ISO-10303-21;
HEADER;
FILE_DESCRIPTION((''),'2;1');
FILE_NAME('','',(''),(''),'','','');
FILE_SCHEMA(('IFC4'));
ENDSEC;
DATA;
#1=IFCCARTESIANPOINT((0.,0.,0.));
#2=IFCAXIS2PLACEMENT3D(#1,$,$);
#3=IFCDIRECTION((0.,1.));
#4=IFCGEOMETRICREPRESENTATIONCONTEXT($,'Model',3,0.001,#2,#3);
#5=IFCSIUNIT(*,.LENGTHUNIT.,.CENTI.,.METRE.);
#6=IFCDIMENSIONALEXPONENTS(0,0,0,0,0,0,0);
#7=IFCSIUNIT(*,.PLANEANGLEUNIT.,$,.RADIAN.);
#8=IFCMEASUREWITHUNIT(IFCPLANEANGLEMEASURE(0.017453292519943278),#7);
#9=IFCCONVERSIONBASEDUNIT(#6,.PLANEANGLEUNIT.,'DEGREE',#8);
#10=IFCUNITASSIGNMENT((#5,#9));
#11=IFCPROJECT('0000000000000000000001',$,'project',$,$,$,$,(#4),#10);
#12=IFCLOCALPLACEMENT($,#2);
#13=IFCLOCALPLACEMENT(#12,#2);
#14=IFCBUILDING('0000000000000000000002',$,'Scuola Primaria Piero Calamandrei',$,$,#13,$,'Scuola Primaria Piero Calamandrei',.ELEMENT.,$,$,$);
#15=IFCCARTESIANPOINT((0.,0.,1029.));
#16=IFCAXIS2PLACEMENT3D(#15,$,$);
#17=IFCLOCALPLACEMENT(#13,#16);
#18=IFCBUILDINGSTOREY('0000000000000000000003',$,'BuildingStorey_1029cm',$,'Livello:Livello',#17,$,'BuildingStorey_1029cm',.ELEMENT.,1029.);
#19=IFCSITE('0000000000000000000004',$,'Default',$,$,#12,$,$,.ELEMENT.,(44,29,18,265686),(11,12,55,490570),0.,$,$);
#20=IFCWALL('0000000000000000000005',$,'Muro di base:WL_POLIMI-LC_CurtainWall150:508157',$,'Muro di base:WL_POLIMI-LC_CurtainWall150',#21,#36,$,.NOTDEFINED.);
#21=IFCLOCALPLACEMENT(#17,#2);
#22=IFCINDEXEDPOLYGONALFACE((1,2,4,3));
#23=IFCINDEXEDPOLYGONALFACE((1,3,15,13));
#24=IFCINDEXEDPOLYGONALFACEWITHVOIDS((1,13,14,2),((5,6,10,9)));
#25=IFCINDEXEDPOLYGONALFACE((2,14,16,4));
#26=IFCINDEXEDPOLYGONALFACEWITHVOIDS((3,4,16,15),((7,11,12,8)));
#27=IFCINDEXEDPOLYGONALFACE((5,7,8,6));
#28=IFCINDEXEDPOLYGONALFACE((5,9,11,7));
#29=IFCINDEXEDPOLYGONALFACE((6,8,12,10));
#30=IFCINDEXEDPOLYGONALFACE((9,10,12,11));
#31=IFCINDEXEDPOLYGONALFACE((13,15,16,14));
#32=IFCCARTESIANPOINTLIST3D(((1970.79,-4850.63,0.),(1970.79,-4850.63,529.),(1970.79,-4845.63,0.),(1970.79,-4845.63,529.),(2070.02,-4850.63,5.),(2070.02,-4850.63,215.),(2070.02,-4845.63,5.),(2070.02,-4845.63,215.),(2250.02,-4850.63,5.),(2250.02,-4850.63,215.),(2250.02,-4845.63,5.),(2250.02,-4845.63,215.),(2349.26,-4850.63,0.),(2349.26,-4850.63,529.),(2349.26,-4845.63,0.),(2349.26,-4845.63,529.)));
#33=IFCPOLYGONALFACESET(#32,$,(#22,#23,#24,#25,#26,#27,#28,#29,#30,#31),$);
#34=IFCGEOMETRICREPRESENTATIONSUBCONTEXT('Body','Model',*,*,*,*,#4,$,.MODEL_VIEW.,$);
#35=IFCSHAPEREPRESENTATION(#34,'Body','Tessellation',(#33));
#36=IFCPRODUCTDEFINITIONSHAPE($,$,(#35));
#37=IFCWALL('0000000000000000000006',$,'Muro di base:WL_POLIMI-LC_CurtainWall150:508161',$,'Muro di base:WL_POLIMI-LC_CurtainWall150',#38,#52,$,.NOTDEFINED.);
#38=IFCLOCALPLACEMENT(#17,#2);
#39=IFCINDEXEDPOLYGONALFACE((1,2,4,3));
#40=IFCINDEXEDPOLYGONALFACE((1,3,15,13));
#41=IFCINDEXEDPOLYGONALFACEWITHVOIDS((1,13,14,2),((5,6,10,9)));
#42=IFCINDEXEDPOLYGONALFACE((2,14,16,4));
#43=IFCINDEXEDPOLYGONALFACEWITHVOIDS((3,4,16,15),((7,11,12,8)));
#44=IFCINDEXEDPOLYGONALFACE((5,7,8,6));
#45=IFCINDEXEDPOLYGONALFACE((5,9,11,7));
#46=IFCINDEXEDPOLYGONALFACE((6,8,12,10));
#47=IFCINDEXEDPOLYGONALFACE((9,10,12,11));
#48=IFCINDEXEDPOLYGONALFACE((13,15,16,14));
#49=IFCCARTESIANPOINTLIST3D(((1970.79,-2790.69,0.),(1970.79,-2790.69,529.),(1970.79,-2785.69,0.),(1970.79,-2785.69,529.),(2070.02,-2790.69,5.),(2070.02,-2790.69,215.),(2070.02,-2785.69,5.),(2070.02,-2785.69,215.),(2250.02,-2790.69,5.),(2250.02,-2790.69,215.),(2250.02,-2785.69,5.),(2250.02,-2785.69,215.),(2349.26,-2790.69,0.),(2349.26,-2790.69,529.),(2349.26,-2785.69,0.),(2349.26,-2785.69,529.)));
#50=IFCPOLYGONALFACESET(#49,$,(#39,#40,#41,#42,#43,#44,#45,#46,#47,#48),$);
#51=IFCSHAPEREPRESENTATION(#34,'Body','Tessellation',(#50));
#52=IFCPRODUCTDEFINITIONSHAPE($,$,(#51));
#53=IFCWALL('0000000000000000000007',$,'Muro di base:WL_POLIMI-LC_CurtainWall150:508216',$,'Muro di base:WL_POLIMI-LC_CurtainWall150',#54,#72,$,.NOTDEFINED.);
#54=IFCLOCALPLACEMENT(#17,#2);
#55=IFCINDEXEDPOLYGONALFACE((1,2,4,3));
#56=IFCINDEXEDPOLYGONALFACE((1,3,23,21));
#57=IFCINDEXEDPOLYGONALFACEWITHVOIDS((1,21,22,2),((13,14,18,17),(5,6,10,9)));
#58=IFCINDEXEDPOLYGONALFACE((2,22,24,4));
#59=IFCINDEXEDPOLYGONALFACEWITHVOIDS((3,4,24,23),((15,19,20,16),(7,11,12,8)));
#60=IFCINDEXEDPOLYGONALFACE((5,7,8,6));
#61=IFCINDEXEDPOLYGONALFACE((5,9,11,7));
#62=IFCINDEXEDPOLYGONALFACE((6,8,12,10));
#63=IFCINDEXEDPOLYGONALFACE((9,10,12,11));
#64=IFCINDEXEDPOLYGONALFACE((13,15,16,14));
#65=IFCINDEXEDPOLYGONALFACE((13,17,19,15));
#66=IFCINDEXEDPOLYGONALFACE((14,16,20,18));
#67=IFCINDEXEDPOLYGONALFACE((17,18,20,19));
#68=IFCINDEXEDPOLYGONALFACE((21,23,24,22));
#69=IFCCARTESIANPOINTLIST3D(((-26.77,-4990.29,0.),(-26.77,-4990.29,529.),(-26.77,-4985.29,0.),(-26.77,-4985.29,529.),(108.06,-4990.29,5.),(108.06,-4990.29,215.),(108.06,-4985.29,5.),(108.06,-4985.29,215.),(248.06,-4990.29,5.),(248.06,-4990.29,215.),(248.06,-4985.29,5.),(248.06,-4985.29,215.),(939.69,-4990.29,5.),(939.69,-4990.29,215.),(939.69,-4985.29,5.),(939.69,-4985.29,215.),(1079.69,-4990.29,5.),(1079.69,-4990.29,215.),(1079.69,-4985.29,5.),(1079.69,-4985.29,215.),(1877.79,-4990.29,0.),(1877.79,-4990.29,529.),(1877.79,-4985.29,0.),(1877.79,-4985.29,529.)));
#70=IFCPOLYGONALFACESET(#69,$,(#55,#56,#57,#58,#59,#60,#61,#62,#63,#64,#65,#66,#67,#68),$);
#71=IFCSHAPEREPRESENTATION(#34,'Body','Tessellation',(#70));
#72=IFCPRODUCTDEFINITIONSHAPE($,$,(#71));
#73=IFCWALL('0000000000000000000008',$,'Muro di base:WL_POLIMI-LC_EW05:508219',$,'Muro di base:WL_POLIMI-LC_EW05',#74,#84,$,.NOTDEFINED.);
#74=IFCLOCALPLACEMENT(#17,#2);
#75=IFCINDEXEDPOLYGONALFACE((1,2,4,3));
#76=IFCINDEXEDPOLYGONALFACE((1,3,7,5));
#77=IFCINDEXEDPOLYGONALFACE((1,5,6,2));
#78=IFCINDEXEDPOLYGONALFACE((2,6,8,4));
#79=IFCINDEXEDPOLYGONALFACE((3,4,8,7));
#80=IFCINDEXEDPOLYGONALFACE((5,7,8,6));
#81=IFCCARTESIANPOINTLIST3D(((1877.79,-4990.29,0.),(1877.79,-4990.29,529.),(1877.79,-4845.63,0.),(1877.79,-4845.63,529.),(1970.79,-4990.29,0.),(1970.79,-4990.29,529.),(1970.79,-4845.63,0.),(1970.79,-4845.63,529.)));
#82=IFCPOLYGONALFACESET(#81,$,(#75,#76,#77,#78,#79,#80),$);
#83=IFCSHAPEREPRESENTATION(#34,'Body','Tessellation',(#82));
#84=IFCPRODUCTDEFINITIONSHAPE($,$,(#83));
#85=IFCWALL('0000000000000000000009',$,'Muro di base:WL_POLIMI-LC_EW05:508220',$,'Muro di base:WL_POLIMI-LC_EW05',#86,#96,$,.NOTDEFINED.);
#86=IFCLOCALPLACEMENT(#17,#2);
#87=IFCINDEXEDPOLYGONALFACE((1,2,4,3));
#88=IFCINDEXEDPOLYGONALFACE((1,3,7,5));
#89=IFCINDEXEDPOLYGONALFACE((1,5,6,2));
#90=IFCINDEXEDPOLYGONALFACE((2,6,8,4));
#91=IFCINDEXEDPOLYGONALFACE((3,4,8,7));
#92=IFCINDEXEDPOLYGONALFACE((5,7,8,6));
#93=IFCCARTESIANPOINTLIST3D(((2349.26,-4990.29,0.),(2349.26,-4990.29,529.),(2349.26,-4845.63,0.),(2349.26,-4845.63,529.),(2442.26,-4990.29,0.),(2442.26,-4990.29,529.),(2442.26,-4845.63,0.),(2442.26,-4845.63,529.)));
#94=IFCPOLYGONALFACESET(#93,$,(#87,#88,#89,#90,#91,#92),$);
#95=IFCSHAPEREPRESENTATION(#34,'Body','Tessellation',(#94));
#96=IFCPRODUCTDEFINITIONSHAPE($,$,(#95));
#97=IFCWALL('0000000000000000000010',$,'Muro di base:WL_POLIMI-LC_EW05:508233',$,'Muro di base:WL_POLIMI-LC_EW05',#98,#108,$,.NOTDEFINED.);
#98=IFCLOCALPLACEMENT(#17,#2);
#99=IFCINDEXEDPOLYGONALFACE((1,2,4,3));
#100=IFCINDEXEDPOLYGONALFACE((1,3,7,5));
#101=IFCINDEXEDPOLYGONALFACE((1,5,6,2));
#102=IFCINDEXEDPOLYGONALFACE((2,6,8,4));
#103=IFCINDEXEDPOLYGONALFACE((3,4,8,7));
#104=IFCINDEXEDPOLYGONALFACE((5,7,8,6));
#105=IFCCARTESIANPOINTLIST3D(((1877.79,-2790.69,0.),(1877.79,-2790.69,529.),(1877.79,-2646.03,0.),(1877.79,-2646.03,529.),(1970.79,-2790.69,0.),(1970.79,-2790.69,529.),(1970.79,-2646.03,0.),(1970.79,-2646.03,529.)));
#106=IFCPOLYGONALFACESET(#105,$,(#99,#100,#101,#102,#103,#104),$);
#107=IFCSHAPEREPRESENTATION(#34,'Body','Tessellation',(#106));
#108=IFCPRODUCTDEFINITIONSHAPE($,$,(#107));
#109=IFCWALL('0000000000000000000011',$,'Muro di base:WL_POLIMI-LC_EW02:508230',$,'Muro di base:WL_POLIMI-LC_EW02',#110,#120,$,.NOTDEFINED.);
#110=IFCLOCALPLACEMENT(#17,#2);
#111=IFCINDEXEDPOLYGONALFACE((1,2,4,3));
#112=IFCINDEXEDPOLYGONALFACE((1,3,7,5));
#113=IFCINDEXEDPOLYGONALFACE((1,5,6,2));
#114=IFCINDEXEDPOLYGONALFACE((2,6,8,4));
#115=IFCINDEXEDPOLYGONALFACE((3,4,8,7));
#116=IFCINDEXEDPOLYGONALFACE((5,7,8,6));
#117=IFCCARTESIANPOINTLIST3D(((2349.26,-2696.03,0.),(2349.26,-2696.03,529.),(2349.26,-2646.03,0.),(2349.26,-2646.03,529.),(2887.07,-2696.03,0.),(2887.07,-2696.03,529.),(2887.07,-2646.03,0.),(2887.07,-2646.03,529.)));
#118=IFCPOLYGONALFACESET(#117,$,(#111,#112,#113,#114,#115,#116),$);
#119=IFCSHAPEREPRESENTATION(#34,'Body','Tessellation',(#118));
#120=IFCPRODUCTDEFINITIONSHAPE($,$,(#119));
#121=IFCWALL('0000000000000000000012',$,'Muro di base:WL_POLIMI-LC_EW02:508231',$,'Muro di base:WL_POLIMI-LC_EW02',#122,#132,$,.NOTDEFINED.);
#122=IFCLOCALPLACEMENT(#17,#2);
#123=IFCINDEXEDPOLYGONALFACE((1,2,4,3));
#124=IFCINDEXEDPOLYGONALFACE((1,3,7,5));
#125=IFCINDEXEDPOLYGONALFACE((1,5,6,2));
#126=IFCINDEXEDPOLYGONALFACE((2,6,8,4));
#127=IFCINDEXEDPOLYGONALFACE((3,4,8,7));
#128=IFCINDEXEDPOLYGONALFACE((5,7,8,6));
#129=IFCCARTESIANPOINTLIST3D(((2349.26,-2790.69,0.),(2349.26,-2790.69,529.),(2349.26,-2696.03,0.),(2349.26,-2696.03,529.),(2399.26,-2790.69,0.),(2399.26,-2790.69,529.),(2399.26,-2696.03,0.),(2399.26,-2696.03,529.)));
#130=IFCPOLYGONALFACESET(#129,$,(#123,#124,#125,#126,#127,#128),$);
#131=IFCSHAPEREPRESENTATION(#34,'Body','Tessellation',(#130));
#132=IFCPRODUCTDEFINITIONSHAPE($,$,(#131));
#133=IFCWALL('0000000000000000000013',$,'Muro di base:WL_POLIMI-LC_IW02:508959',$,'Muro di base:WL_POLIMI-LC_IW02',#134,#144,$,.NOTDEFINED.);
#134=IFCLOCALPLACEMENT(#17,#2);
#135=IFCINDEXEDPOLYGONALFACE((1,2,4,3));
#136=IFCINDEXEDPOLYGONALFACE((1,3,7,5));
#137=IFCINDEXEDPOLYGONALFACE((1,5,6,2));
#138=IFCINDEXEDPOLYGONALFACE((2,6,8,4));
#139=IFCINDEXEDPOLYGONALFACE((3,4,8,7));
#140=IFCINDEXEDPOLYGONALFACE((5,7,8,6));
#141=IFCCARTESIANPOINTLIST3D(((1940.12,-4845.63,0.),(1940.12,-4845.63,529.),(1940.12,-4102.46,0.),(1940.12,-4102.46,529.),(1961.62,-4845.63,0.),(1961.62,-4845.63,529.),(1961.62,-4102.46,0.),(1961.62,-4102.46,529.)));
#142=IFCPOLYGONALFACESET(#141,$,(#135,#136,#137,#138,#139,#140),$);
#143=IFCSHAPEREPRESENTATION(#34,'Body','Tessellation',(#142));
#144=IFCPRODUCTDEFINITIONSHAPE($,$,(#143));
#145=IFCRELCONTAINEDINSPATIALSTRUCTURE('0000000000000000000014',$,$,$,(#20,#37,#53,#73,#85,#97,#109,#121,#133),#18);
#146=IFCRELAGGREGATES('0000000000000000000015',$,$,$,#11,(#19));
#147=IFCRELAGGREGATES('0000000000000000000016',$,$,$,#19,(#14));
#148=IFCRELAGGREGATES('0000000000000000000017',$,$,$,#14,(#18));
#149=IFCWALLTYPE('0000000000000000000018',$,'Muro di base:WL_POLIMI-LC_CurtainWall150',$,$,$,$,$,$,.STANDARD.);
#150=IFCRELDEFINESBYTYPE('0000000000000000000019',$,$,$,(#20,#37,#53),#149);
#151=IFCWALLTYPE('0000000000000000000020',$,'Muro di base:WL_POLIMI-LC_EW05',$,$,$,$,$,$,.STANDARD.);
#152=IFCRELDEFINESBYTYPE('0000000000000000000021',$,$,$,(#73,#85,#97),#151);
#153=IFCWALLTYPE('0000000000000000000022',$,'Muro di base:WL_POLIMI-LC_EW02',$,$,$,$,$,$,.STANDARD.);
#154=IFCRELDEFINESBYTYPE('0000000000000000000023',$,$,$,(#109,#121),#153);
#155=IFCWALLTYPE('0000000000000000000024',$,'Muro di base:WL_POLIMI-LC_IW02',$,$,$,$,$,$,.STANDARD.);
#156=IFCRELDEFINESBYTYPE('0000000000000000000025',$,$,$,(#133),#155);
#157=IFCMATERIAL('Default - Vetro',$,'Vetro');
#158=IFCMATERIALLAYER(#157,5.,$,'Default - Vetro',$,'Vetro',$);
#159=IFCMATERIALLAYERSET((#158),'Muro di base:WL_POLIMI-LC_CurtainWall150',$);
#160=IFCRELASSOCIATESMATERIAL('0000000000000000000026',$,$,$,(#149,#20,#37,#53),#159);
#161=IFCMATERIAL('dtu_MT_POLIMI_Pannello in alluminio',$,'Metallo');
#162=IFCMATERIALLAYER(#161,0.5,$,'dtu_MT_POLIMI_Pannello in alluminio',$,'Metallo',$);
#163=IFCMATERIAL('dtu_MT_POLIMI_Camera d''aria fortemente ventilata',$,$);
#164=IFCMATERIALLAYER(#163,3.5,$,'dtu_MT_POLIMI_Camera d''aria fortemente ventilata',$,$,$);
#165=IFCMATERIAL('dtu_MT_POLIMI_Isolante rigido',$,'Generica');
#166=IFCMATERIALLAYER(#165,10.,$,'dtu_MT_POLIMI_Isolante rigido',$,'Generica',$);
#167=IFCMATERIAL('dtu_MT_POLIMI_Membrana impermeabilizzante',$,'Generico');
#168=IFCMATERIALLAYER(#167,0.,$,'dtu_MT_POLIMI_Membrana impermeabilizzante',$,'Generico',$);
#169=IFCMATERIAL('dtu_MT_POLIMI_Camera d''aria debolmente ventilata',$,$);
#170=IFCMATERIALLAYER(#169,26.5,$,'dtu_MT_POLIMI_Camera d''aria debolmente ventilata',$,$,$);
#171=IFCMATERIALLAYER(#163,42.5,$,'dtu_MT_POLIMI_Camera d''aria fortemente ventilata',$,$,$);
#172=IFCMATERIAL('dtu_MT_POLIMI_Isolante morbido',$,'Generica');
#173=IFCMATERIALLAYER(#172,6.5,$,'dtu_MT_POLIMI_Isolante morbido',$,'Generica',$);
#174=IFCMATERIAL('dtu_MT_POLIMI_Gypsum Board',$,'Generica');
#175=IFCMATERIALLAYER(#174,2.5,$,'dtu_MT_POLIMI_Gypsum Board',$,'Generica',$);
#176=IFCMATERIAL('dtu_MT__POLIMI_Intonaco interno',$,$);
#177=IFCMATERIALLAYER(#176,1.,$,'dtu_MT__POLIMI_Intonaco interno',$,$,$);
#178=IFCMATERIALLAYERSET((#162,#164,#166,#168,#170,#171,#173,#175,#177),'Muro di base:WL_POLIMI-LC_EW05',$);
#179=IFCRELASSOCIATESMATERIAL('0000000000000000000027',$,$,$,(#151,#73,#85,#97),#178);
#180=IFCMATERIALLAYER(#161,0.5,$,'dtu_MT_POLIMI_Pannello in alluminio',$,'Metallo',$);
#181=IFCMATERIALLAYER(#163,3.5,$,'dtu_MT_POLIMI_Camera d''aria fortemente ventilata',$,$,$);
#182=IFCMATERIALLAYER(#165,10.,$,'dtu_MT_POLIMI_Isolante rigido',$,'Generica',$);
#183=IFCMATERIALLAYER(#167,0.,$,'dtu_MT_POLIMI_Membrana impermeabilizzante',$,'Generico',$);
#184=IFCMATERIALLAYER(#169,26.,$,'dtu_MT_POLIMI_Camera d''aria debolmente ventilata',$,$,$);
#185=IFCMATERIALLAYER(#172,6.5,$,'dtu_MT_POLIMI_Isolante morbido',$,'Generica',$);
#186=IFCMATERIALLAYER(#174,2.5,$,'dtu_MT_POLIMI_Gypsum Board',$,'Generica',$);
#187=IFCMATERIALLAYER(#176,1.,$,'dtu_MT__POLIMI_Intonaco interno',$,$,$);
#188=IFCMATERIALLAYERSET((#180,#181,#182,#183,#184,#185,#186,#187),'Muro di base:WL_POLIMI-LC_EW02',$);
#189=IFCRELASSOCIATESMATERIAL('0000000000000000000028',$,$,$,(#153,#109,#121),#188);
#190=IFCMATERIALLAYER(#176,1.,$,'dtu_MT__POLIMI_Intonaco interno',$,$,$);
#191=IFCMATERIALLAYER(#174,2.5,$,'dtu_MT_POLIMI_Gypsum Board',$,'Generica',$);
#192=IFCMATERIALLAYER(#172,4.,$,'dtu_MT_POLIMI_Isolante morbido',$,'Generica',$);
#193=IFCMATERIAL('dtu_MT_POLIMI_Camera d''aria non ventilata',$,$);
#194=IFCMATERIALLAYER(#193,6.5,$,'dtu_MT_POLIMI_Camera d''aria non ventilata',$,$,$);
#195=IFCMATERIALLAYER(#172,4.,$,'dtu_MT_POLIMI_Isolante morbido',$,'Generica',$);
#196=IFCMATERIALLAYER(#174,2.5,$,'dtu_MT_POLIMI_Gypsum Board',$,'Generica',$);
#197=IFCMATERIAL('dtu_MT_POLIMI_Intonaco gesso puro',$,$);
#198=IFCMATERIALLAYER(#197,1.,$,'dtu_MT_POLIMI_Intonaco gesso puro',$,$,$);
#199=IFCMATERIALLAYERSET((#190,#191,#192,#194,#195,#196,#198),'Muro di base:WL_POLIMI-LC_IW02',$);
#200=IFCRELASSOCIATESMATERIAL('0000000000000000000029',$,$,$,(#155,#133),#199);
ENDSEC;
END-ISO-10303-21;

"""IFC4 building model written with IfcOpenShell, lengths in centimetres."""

from ifc_helpers import new_model, entity, si_unit, converted_unit, direction, frame, frame_2d, origin, place, context, subcontext, project, spatial, rectangle, extrude, material, layer, layer_set, layer_usage, type_object, element, save


model = new_model("IFC4")

# Units and contexts
model_context = context("Model", 3, precision=0.001, world=origin(), true_north=direction((0.0, 1.0)))
body_context = subcontext(model_context, "Body", "Model", "MODEL_VIEW")
ifc_project = project(units=[si_unit("LENGTHUNIT", "METRE", prefix="CENTI"), converted_unit("PLANEANGLEUNIT", "DEGREE", entity("IfcPlaneAngleMeasure", 0.017453292519943278), si_unit("PLANEANGLEUNIT", "RADIAN"), dimensions=[0, 0, 0, 0, 0, 0, 0])], contexts=[model_context])

# Site, building, storey
site_placement = place(None, origin())
site = spatial("IfcSite", under=ifc_project, at=site_placement, Name="Default", CompositionType="ELEMENT", RefLatitude=(44, 29, 18, 265686), RefLongitude=(11, 12, 55, 490570), RefElevation=0.0)
building_placement = place(site_placement, origin())
building = spatial("IfcBuilding", under=site, at=building_placement, Name="Scuola Primaria Piero Calamandrei", LongName="Scuola Primaria Piero Calamandrei", CompositionType="ELEMENT")
storey_placement = place(building_placement, frame((0.0, 0.0, 1029.0)))
storey = spatial("IfcBuildingStorey", under=building, at=storey_placement, Name="BuildingStorey_1029cm", ObjectType="Livello:Livello", LongName="BuildingStorey_1029cm", CompositionType="ELEMENT", Elevation=1029.0)

# Wall, openings
ifc_material_1 = material(Name="Default - Vetro", Category="Vetro")
ifc_layer_1 = layer(ifc_material_1, 5.0, Name="Default - Vetro", Category="Vetro")
ifc_layer_set_1 = layer_set([ifc_layer_1], Name="Muro di base:WL_POLIMI-LC_CurtainWall150")
ifc_layer_usage_1 = layer_usage(ifc_layer_set_1, "AXIS2", "NEGATIVE", 2.5)
wall_type_1 = type_object("IfcWallType", Name="Muro di base:WL_POLIMI-LC_CurtainWall150", PredefinedType="STANDARD", material=ifc_layer_set_1)
wall_1_placement = place(storey_placement, frame((2349.26, -4848.13, 0.0), z_axis=(0.0, 0.0, 1.0), x_axis=(-1.0, 0.0, 0.0)))
wall_1 = element("IfcWall", 1, at=wall_1_placement, inside=storey, type_object=wall_type_1, material=ifc_layer_usage_1, Name="Muro di base:WL_POLIMI-LC_CurtainWall150:508157", ObjectType="Muro di base:WL_POLIMI-LC_CurtainWall150", PredefinedType="NOTDEFINED", context=body_context, shape_type="SweptSolid", body=[
    extrude(rectangle(XDim=5.0, YDim=378.47, at=frame_2d((0.0, 0.0), x_axis=(1.0, 0.0))), frame((189.23, 0.0, 0.0), z_axis=(0.0, 0.0, 1.0), x_axis=(0.0, 1.0, 0.0)), (0.0, 0.0, 1.0), 529.0),
])
opening_1_placement = place(storey_placement, frame((2349.26, -4848.13, 0.0), z_axis=(0.0, 0.0, 1.0), x_axis=(-1.0, 0.0, 0.0)))
element("IfcOpeningElement", 2, at=opening_1_placement, cuts=wall_1, PredefinedType="OPENING", context=body_context, shape_type="SweptSolid", body=[
    extrude(rectangle(XDim=210.0, YDim=180.0, at=frame_2d((0.0, 0.0), x_axis=(0.0, 1.0))), frame((189.23, -2.5, 110.0), z_axis=(0.0, 1.0, 0.0), x_axis=(1.0, 0.0, 0.0)), (0.0, 0.0, 1.0), 5.0),
])
opening_2_placement = place(wall_1_placement, frame((99.23, -2.5, 5.0)))
element("IfcOpeningElement", 3, at=opening_2_placement, cuts=wall_1, PredefinedType="OPENING", context=body_context, shape_type="SweptSolid", body=[
    extrude(rectangle(XDim=210.0, YDim=180.0, at=frame_2d((105.0, 90.0), x_axis=(-1.0, 0.0))), frame((0.0, 0.0, 0.0), z_axis=(0.0, 1.0, 0.0), x_axis=(0.0, 0.0, 1.0)), (0.0, 0.0, 1.0), 5.0),
])

# Wall, opening
ifc_layer_usage_2 = layer_usage(ifc_layer_set_1, "AXIS2", "NEGATIVE", 2.5)
wall_2_placement = place(storey_placement, frame((1970.79, -2788.19, 0.0)))
wall_2 = element("IfcWall", 4, at=wall_2_placement, inside=storey, type_object=wall_type_1, material=ifc_layer_usage_2, Name="Muro di base:WL_POLIMI-LC_CurtainWall150:508161", ObjectType="Muro di base:WL_POLIMI-LC_CurtainWall150", PredefinedType="NOTDEFINED", context=body_context, shape_type="SweptSolid", body=[
    extrude(rectangle(XDim=378.47, YDim=5.0, at=frame_2d((189.23, 0.0), x_axis=(-1.0, 0.0))), origin(), (0.0, 0.0, 1.0), 529.0),
])
opening_3_placement = place(wall_2_placement, frame((99.23, -2.5, 5.0)))
element("IfcOpeningElement", 5, at=opening_3_placement, cuts=wall_2, PredefinedType="OPENING", context=body_context, shape_type="SweptSolid", body=[
    extrude(rectangle(XDim=210.0, YDim=180.0, at=frame_2d((105.0, 90.0), x_axis=(-1.0, 0.0))), frame((0.0, 0.0, 0.0), z_axis=(0.0, 1.0, 0.0), x_axis=(0.0, 0.0, 1.0)), (0.0, 0.0, 1.0), 5.0),
])

# Wall, openings
ifc_layer_usage_3 = layer_usage(ifc_layer_set_1, "AXIS2", "NEGATIVE", 2.5)
wall_3_placement = place(storey_placement, frame((1877.79, -4987.79, 0.0), z_axis=(0.0, 0.0, 1.0), x_axis=(-1.0, 0.0, 0.0)))
wall_3 = element("IfcWall", 6, at=wall_3_placement, inside=storey, type_object=wall_type_1, material=ifc_layer_usage_3, Name="Muro di base:WL_POLIMI-LC_CurtainWall150:508216", ObjectType="Muro di base:WL_POLIMI-LC_CurtainWall150", PredefinedType="NOTDEFINED", context=body_context, shape_type="SweptSolid", body=[
    extrude(rectangle(XDim=1904.56, YDim=5.0, at=frame_2d((952.28, 0.0), x_axis=(-1.0, 0.0))), origin(), (0.0, 0.0, 1.0), 529.0),
])
opening_4_placement = place(wall_3_placement, frame((1629.73, -2.5, 5.0)))
element("IfcOpeningElement", 7, at=opening_4_placement, cuts=wall_3, PredefinedType="OPENING", context=body_context, shape_type="SweptSolid", body=[
    extrude(rectangle(XDim=210.0, YDim=140.0, at=frame_2d((105.0, 70.0), x_axis=(-1.0, 0.0))), frame((0.0, 0.0, 0.0), z_axis=(0.0, 1.0, 0.0), x_axis=(0.0, 0.0, 1.0)), (0.0, 0.0, 1.0), 5.0),
])
opening_5_placement = place(wall_3_placement, frame((798.1, -2.5, 5.0)))
element("IfcOpeningElement", 8, at=opening_5_placement, cuts=wall_3, PredefinedType="OPENING", context=body_context, shape_type="SweptSolid", body=[
    extrude(rectangle(XDim=210.0, YDim=140.0, at=frame_2d((105.0, 70.0), x_axis=(-1.0, 0.0))), frame((0.0, 0.0, 0.0), z_axis=(0.0, 1.0, 0.0), x_axis=(0.0, 0.0, 1.0)), (0.0, 0.0, 1.0), 5.0),
])

# Walls
ifc_material_2 = material(Name="dtu_MT_POLIMI_Pannello in alluminio", Category="Metallo")
ifc_layer_2 = layer(ifc_material_2, 0.5, Name="dtu_MT_POLIMI_Pannello in alluminio", Category="Metallo")
ifc_material_3 = material(Name="dtu_MT_POLIMI_Camera d'aria fortemente ventilata")
ifc_layer_3 = layer(ifc_material_3, 3.5, Name="dtu_MT_POLIMI_Camera d'aria fortemente ventilata")
ifc_material_4 = material(Name="dtu_MT_POLIMI_Isolante rigido", Category="Generica")
ifc_layer_4 = layer(ifc_material_4, 10.0, Name="dtu_MT_POLIMI_Isolante rigido", Category="Generica")
ifc_material_5 = material(Name="dtu_MT_POLIMI_Membrana impermeabilizzante", Category="Generico")
ifc_layer_5 = layer(ifc_material_5, 0.0, Name="dtu_MT_POLIMI_Membrana impermeabilizzante", Category="Generico")
ifc_material_6 = material(Name="dtu_MT_POLIMI_Camera d'aria debolmente ventilata")
ifc_layer_6 = layer(ifc_material_6, 26.5, Name="dtu_MT_POLIMI_Camera d'aria debolmente ventilata")
ifc_layer_7 = layer(ifc_material_3, 42.5, Name="dtu_MT_POLIMI_Camera d'aria fortemente ventilata")
ifc_material_7 = material(Name="dtu_MT_POLIMI_Isolante morbido", Category="Generica")
ifc_layer_8 = layer(ifc_material_7, 6.5, Name="dtu_MT_POLIMI_Isolante morbido", Category="Generica")
ifc_material_8 = material(Name="dtu_MT_POLIMI_Gypsum Board", Category="Generica")
ifc_layer_9 = layer(ifc_material_8, 2.5, Name="dtu_MT_POLIMI_Gypsum Board", Category="Generica")
ifc_material_9 = material(Name="dtu_MT__POLIMI_Intonaco interno")
ifc_layer_10 = layer(ifc_material_9, 1.0, Name="dtu_MT__POLIMI_Intonaco interno")
ifc_layer_set_2 = layer_set([ifc_layer_2, ifc_layer_3, ifc_layer_4, ifc_layer_5, ifc_layer_6, ifc_layer_7, ifc_layer_8, ifc_layer_9, ifc_layer_10], Name="Muro di base:WL_POLIMI-LC_EW05")
ifc_layer_usage_4 = layer_usage(ifc_layer_set_2, "AXIS2", "NEGATIVE", 46.5)
wall_type_2 = type_object("IfcWallType", Name="Muro di base:WL_POLIMI-LC_EW05", PredefinedType="STANDARD", material=ifc_layer_set_2)
wall_4_placement = place(storey_placement, frame((1924.29, -4845.63, 0.0), z_axis=(0.0, 0.0, 1.0), x_axis=(0.0, -1.0, 0.0)))
element("IfcWall", 9, at=wall_4_placement, inside=storey, type_object=wall_type_2, material=ifc_layer_usage_4, Name="Muro di base:WL_POLIMI-LC_EW05:508219", ObjectType="Muro di base:WL_POLIMI-LC_EW05", PredefinedType="NOTDEFINED", context=body_context, shape_type="SweptSolid", body=[
    extrude(rectangle(XDim=144.66, YDim=93.0, at=frame_2d((72.33, 0.0), x_axis=(-1.0, 0.0))), origin(), (0.0, 0.0, 1.0), 529.0),
])
ifc_layer_usage_5 = layer_usage(ifc_layer_set_2, "AXIS2", "NEGATIVE", 46.5)
wall_5_placement = place(storey_placement, frame((2395.76, -4990.29, 0.0), z_axis=(0.0, 0.0, 1.0), x_axis=(0.0, 1.0, 0.0)))
element("IfcWall", 10, at=wall_5_placement, inside=storey, type_object=wall_type_2, material=ifc_layer_usage_5, Name="Muro di base:WL_POLIMI-LC_EW05:508220", ObjectType="Muro di base:WL_POLIMI-LC_EW05", PredefinedType="NOTDEFINED", context=body_context, shape_type="SweptSolid", body=[
    extrude(rectangle(XDim=144.66, YDim=93.0, at=frame_2d((72.33, 0.0), x_axis=(-1.0, 0.0))), origin(), (0.0, 0.0, 1.0), 529.0),
])
ifc_layer_usage_6 = layer_usage(ifc_layer_set_2, "AXIS2", "NEGATIVE", 46.5)
wall_6_placement = place(storey_placement, frame((1924.29, -2646.03, 0.0), z_axis=(0.0, 0.0, 1.0), x_axis=(0.0, -1.0, 0.0)))
element("IfcWall", 11, at=wall_6_placement, inside=storey, type_object=wall_type_2, material=ifc_layer_usage_6, Name="Muro di base:WL_POLIMI-LC_EW05:508233", ObjectType="Muro di base:WL_POLIMI-LC_EW05", PredefinedType="NOTDEFINED", context=body_context, shape_type="SweptSolid", body=[
    extrude(rectangle(XDim=144.66, YDim=93.0, at=frame_2d((72.33, 0.0), x_axis=(-1.0, 0.0))), origin(), (0.0, 0.0, 1.0), 529.0),
])
ifc_layer_11 = layer(ifc_material_2, 0.5, Name="dtu_MT_POLIMI_Pannello in alluminio", Category="Metallo")
ifc_layer_12 = layer(ifc_material_3, 3.5, Name="dtu_MT_POLIMI_Camera d'aria fortemente ventilata")
ifc_layer_13 = layer(ifc_material_4, 10.0, Name="dtu_MT_POLIMI_Isolante rigido", Category="Generica")
ifc_layer_14 = layer(ifc_material_5, 0.0, Name="dtu_MT_POLIMI_Membrana impermeabilizzante", Category="Generico")
ifc_layer_15 = layer(ifc_material_6, 26.0, Name="dtu_MT_POLIMI_Camera d'aria debolmente ventilata")
ifc_layer_16 = layer(ifc_material_7, 6.5, Name="dtu_MT_POLIMI_Isolante morbido", Category="Generica")
ifc_layer_17 = layer(ifc_material_8, 2.5, Name="dtu_MT_POLIMI_Gypsum Board", Category="Generica")
ifc_layer_18 = layer(ifc_material_9, 1.0, Name="dtu_MT__POLIMI_Intonaco interno")
ifc_layer_set_3 = layer_set([ifc_layer_11, ifc_layer_12, ifc_layer_13, ifc_layer_14, ifc_layer_15, ifc_layer_16, ifc_layer_17, ifc_layer_18], Name="Muro di base:WL_POLIMI-LC_EW02")
ifc_layer_usage_7 = layer_usage(ifc_layer_set_3, "AXIS2", "NEGATIVE", 25.0)
wall_type_3 = type_object("IfcWallType", Name="Muro di base:WL_POLIMI-LC_EW02", PredefinedType="STANDARD", material=ifc_layer_set_3)
wall_7_placement = place(storey_placement, frame((2349.26, -2671.03, 0.0)))
element("IfcWall", 12, at=wall_7_placement, inside=storey, type_object=wall_type_3, material=ifc_layer_usage_7, Name="Muro di base:WL_POLIMI-LC_EW02:508230", ObjectType="Muro di base:WL_POLIMI-LC_EW02", PredefinedType="NOTDEFINED", context=body_context, shape_type="SweptSolid", body=[
    extrude(rectangle(XDim=537.82, YDim=50.0, at=frame_2d((268.91, 0.0), x_axis=(-1.0, 0.0))), origin(), (0.0, 0.0, 1.0), 529.0),
])
ifc_layer_usage_8 = layer_usage(ifc_layer_set_3, "AXIS2", "NEGATIVE", 25.0)
wall_8_placement = place(storey_placement, frame((2374.26, -2790.69, 0.0), z_axis=(0.0, 0.0, 1.0), x_axis=(0.0, 1.0, 0.0)))
element("IfcWall", 13, at=wall_8_placement, inside=storey, type_object=wall_type_3, material=ifc_layer_usage_8, Name="Muro di base:WL_POLIMI-LC_EW02:508231", ObjectType="Muro di base:WL_POLIMI-LC_EW02", PredefinedType="NOTDEFINED", context=body_context, shape_type="SweptSolid", body=[
    extrude(rectangle(XDim=94.66, YDim=50.0, at=frame_2d((47.33, 0.0), x_axis=(-1.0, 0.0))), origin(), (0.0, 0.0, 1.0), 529.0),
])
ifc_layer_19 = layer(ifc_material_9, 1.0, Name="dtu_MT__POLIMI_Intonaco interno")
ifc_layer_20 = layer(ifc_material_8, 2.5, Name="dtu_MT_POLIMI_Gypsum Board", Category="Generica")
ifc_layer_21 = layer(ifc_material_7, 4.0, Name="dtu_MT_POLIMI_Isolante morbido", Category="Generica")
ifc_material_10 = material(Name="dtu_MT_POLIMI_Camera d'aria non ventilata")
ifc_layer_22 = layer(ifc_material_10, 6.5, Name="dtu_MT_POLIMI_Camera d'aria non ventilata")
ifc_layer_23 = layer(ifc_material_7, 4.0, Name="dtu_MT_POLIMI_Isolante morbido", Category="Generica")
ifc_layer_24 = layer(ifc_material_8, 2.5, Name="dtu_MT_POLIMI_Gypsum Board", Category="Generica")
ifc_material_11 = material(Name="dtu_MT_POLIMI_Intonaco gesso puro")
ifc_layer_25 = layer(ifc_material_11, 1.0, Name="dtu_MT_POLIMI_Intonaco gesso puro")
ifc_layer_set_4 = layer_set([ifc_layer_19, ifc_layer_20, ifc_layer_21, ifc_layer_22, ifc_layer_23, ifc_layer_24, ifc_layer_25], Name="Muro di base:WL_POLIMI-LC_IW02")
ifc_layer_usage_9 = layer_usage(ifc_layer_set_4, "AXIS2", "NEGATIVE", 10.75)
wall_type_4 = type_object("IfcWallType", Name="Muro di base:WL_POLIMI-LC_IW02", PredefinedType="STANDARD", material=ifc_layer_set_4)
wall_9_placement = place(storey_placement, frame((1950.87, -4845.63, 0.0), z_axis=(0.0, 0.0, 1.0), x_axis=(0.0, 1.0, 0.0)))
element("IfcWall", 14, at=wall_9_placement, inside=storey, type_object=wall_type_4, material=ifc_layer_usage_9, Name="Muro di base:WL_POLIMI-LC_IW02:508959", ObjectType="Muro di base:WL_POLIMI-LC_IW02", PredefinedType="NOTDEFINED", context=body_context, shape_type="SweptSolid", body=[
    extrude(rectangle(XDim=743.17, YDim=21.5, at=frame_2d((371.58, 0.0), x_axis=(-1.0, 0.0))), origin(), (0.0, 0.0, 1.0), 529.0),
])

save(model, "model.ifc")
